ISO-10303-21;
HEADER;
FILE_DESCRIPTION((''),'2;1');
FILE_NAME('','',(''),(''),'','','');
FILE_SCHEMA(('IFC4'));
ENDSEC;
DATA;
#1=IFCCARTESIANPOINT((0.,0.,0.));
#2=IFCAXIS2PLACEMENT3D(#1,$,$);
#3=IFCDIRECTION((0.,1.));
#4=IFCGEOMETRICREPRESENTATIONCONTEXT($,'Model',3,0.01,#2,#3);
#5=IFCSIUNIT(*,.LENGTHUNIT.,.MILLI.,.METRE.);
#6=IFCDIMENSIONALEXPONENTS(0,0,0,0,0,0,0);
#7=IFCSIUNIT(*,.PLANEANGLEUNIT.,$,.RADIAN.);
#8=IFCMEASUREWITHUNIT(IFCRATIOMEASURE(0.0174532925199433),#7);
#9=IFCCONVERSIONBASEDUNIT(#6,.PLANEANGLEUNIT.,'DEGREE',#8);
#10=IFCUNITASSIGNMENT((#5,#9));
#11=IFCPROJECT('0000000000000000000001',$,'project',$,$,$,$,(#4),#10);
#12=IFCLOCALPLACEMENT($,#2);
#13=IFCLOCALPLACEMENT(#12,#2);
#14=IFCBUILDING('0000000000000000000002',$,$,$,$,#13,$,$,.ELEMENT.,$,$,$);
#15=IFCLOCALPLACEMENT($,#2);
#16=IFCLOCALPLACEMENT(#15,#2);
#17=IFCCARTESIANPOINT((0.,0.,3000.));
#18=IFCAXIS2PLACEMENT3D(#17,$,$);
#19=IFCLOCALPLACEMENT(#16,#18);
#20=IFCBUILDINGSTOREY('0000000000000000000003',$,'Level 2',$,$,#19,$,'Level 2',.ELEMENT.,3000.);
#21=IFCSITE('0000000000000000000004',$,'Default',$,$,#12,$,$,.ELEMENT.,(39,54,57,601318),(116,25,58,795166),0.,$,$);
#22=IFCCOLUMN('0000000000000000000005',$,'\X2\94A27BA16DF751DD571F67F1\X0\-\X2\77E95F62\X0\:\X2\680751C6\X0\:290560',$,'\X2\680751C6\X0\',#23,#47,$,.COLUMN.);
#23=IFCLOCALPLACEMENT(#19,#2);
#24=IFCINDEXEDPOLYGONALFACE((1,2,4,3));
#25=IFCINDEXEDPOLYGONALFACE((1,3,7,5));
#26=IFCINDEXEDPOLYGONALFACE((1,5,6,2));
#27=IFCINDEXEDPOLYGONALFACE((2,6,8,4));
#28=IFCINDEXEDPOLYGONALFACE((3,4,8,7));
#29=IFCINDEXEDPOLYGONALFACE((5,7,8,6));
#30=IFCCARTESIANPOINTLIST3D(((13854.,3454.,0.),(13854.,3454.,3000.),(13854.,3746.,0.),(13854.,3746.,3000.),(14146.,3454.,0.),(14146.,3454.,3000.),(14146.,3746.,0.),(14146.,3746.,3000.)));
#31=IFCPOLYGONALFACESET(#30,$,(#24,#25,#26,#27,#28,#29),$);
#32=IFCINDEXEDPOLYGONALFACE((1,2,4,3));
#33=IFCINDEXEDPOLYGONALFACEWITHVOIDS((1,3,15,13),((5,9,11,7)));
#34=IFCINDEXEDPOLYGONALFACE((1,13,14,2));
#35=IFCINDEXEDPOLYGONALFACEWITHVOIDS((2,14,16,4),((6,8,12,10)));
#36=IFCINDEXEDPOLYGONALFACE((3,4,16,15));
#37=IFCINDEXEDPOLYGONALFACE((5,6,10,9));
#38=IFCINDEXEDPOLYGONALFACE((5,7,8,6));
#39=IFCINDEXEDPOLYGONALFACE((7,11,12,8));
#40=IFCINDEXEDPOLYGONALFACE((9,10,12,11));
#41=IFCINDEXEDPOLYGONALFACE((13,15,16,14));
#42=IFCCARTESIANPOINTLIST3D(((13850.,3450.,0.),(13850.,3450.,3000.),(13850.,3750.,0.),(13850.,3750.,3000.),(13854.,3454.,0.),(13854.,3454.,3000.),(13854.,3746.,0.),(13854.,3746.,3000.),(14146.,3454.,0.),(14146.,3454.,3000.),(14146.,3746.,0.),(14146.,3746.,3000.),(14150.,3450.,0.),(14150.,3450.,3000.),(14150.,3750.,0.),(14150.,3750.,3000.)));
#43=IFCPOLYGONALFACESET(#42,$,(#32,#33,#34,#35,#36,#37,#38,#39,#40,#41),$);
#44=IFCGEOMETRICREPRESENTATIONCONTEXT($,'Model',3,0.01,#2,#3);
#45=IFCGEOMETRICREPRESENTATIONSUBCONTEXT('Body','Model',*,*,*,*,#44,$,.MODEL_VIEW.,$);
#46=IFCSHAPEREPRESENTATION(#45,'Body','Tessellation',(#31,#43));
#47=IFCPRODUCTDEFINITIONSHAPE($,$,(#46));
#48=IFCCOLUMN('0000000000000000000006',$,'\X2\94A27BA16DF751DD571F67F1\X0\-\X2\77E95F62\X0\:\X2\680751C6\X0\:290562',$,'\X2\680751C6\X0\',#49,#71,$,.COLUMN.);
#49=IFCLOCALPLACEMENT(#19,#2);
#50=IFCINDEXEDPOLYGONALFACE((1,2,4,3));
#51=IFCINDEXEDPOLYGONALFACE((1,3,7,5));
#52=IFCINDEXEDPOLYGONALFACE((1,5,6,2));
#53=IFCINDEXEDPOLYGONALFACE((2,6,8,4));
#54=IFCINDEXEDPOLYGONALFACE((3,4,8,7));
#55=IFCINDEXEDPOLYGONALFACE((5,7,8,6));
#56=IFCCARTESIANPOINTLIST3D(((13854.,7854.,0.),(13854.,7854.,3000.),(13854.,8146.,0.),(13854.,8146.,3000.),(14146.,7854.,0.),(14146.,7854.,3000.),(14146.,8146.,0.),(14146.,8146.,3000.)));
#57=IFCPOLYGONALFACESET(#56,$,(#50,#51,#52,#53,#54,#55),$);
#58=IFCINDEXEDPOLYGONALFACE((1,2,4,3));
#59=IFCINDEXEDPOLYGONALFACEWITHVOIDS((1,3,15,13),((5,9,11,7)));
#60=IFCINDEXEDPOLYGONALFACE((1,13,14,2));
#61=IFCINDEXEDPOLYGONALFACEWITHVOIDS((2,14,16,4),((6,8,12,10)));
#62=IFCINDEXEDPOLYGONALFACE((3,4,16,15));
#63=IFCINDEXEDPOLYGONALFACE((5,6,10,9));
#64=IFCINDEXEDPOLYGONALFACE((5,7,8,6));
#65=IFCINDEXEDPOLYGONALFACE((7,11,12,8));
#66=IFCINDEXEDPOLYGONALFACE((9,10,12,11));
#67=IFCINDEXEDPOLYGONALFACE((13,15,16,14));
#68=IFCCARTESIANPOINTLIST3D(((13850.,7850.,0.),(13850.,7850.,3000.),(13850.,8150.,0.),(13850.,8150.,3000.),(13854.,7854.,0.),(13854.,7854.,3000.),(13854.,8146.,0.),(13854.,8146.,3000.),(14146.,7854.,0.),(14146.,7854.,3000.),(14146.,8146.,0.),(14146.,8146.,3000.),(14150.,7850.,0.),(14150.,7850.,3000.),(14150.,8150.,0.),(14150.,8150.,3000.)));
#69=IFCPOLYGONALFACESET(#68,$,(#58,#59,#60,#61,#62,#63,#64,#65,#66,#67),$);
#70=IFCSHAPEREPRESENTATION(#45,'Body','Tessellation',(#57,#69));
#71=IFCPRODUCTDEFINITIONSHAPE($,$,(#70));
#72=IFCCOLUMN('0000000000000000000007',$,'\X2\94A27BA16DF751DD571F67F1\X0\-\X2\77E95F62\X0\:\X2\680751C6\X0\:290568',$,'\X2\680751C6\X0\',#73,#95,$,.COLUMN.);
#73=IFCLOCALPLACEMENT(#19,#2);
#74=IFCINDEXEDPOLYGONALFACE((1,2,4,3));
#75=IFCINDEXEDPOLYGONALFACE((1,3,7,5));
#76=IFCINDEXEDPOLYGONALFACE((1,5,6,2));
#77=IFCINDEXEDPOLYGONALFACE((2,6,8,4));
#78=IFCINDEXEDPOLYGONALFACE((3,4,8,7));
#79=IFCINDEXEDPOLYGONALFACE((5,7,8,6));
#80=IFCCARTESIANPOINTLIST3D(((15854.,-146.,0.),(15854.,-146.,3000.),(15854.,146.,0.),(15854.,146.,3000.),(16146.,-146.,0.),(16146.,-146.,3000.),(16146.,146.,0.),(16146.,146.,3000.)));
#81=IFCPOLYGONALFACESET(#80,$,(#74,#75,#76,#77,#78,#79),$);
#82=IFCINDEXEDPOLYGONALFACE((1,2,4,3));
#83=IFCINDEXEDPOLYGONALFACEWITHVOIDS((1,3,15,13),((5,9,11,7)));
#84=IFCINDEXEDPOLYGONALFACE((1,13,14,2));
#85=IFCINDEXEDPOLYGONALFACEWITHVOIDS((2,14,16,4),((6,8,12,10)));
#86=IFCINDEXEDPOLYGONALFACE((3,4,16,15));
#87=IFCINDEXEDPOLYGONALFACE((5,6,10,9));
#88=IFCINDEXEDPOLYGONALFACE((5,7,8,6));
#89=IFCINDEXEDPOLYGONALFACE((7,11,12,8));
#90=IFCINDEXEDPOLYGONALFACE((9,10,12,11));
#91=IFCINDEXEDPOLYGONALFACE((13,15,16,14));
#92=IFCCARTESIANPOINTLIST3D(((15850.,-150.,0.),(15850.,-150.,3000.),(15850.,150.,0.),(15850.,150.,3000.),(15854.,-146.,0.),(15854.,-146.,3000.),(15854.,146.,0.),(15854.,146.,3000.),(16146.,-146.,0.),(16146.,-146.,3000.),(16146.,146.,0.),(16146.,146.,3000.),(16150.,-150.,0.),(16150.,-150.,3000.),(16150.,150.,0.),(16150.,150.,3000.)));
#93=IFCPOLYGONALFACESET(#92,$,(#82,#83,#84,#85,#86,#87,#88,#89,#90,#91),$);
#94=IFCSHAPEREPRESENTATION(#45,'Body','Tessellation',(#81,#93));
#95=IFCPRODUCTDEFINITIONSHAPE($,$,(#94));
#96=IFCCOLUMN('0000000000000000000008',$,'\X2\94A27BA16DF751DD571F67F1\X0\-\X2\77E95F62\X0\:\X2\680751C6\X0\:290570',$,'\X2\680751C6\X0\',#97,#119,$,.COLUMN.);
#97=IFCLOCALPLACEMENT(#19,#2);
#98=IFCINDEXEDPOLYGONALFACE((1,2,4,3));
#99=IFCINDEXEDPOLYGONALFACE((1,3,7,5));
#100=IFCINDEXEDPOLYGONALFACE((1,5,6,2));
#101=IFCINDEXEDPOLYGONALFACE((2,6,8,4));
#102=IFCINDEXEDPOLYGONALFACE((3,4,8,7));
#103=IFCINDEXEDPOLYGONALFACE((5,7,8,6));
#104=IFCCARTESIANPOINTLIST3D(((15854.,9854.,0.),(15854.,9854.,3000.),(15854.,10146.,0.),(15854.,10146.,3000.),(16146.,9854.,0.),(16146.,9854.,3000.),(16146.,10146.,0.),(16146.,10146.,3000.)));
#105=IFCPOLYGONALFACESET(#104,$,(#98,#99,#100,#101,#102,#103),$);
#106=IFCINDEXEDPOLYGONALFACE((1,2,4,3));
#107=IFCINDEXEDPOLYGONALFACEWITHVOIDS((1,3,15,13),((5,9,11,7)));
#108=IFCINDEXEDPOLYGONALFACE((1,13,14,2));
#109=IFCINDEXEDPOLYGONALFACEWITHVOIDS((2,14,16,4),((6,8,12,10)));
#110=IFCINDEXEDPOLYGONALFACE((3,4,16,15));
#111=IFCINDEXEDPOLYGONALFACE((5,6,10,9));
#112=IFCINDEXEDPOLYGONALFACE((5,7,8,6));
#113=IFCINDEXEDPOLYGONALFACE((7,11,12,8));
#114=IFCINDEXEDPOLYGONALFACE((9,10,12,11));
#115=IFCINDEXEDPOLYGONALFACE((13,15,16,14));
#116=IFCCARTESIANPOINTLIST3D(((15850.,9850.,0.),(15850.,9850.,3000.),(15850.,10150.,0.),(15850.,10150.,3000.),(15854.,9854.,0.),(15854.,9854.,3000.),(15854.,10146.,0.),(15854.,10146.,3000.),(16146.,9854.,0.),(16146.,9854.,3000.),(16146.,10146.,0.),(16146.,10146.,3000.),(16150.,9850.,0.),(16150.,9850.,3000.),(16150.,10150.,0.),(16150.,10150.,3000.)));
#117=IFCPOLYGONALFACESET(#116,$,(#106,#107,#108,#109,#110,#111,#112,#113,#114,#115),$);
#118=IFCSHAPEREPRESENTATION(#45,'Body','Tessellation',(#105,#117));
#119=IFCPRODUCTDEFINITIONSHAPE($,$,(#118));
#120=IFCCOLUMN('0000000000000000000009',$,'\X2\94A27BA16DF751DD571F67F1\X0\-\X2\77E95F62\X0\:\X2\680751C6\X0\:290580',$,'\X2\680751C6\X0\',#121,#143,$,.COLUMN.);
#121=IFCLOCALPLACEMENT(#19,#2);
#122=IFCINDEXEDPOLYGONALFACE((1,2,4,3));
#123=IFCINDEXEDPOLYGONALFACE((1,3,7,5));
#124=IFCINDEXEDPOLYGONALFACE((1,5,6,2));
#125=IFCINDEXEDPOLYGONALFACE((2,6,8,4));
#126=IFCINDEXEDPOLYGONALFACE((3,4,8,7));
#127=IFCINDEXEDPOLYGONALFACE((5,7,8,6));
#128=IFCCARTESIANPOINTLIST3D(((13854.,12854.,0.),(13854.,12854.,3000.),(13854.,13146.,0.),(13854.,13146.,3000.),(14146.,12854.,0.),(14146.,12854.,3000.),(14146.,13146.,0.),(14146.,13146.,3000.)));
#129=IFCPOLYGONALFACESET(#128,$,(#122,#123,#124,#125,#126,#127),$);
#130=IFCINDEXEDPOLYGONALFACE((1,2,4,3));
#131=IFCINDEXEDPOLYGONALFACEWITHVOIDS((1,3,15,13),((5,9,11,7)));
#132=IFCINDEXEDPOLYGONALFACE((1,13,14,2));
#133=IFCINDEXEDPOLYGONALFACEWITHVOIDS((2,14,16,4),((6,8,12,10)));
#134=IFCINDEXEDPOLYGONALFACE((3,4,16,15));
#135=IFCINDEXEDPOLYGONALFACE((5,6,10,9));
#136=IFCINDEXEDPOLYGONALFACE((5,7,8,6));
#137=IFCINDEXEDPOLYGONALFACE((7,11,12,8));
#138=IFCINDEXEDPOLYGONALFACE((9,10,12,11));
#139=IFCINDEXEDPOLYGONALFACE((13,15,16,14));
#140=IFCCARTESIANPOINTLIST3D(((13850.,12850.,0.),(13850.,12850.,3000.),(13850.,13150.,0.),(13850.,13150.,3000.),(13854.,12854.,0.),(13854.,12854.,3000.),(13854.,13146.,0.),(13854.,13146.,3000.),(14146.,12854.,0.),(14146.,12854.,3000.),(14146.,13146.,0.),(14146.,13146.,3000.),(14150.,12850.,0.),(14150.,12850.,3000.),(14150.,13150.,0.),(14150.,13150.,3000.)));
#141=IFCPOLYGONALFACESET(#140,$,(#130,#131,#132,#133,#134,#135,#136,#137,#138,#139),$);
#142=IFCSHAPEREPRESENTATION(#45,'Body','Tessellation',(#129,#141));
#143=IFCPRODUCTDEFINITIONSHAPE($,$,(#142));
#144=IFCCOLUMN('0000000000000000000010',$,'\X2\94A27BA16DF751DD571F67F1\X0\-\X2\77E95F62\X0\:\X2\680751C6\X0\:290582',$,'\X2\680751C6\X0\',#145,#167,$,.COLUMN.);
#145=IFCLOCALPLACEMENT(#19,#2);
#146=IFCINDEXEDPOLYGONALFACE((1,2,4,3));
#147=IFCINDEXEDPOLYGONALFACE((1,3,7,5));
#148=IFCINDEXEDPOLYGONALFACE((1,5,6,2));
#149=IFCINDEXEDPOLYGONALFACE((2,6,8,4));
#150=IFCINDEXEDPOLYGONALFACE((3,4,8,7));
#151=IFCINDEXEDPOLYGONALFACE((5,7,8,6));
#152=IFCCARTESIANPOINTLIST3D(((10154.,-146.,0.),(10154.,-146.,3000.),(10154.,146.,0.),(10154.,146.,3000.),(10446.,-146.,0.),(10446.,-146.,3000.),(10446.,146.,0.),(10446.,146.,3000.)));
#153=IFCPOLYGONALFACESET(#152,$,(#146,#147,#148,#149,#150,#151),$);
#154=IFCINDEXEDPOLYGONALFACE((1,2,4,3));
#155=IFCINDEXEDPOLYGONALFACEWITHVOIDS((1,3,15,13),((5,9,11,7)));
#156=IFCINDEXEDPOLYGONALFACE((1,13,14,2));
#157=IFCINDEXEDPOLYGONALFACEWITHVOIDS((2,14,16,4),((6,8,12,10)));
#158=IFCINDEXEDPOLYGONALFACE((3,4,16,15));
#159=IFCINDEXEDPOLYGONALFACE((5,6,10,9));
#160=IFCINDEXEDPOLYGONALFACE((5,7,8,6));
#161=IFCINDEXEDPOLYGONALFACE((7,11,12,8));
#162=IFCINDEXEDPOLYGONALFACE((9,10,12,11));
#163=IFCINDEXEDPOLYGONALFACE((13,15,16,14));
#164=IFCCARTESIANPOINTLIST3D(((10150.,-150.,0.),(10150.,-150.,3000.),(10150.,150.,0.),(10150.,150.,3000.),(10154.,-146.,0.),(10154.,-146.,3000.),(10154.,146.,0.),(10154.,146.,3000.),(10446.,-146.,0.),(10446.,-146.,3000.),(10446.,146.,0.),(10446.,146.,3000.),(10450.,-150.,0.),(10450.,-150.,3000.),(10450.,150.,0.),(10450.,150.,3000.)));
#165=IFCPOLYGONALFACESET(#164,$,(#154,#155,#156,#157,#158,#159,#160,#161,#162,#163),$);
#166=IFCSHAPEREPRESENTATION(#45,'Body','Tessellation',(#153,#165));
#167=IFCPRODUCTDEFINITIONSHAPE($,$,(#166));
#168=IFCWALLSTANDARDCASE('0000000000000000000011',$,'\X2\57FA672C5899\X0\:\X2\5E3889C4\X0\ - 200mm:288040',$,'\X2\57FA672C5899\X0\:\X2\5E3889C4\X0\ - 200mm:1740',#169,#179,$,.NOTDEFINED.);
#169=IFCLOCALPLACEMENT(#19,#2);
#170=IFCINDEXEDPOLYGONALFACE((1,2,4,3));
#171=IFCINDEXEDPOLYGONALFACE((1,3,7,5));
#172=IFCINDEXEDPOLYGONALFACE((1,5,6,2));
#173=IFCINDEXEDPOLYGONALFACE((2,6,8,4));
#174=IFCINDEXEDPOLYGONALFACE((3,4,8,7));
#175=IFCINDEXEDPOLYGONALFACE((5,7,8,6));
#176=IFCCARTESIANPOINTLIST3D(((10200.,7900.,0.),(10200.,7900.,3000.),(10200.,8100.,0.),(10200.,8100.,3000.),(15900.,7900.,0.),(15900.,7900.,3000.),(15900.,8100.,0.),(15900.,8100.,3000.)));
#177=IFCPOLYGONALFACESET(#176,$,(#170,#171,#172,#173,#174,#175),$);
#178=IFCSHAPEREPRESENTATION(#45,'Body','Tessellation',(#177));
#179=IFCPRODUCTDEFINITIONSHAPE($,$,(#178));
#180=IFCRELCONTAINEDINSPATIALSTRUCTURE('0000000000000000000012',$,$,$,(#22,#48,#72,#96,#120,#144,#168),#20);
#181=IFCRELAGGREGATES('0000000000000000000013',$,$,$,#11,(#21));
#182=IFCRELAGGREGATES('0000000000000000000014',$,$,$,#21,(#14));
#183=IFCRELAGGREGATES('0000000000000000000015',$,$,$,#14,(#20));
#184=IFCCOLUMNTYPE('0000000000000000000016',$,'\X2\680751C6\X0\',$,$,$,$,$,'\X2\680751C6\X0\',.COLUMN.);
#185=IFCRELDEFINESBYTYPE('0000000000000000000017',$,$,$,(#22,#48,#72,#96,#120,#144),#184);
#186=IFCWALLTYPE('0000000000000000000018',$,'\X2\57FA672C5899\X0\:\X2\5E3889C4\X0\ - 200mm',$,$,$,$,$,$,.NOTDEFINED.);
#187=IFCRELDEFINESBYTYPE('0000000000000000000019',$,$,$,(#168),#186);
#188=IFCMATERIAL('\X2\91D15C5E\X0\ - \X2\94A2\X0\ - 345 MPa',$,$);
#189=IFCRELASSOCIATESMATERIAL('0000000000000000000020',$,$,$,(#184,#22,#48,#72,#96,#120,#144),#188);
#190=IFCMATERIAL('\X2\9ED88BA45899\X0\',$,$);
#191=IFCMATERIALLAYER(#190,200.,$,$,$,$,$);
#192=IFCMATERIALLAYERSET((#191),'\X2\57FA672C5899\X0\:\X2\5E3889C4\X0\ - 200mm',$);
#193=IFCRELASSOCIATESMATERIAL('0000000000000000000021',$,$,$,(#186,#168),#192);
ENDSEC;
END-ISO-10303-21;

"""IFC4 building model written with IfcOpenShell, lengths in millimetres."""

from ifc_helpers import new_model, entity, si_unit, converted_unit, direction, frame, frame_2d, origin, origin_2d_with_axis, place, context, subcontext, project, spatial, polyline, rectangle, outline, extrude, source, transform, mapped, material, layer, layer_set, layer_usage, type_object, type_shapes, element, save


model = new_model("IFC4")

# Units and contexts
model_context_1 = context("Model", 3, precision=0.01, world=origin(), true_north=direction((0.0, 1.0)))
model_context_2 = context("Model", 3, precision=0.01, world=origin(), true_north=direction((0.0, 1.0)))
body_context = subcontext(model_context_2, "Body", "Model", "MODEL_VIEW")
ifc_project = project(units=[si_unit("LENGTHUNIT", "METRE", prefix="MILLI"), converted_unit("PLANEANGLEUNIT", "DEGREE", entity("IfcRatioMeasure", 0.0174532925199433), si_unit("PLANEANGLEUNIT", "RADIAN"), dimensions=[0, 0, 0, 0, 0, 0, 0])], contexts=[model_context_1])

# Site, building, storey
site_placement = place(None, origin())
site = spatial("IfcSite", under=ifc_project, at=site_placement, Name="Default", CompositionType="ELEMENT", RefLatitude=(39, 54, 57, 601318), RefLongitude=(116, 25, 58, 795166), RefElevation=0.0)
building_placement = place(site_placement, origin())
building = spatial("IfcBuilding", under=site, at=building_placement, CompositionType="ELEMENT")
placement_1 = place(None, origin())
placement_2 = place(placement_1, origin())
storey_placement = place(placement_2, frame((0.0, 0.0, 3000.0)))
storey = spatial("IfcBuildingStorey", under=building, at=storey_placement, Name="Level 2", LongName="Level 2", CompositionType="ELEMENT", Elevation=3000.0)

# Columns
ifc_material_1 = material(Name="金属 - 钢 - 345 MPa")
column_type = type_object("IfcColumnType", Name="标准", ElementType="标准", PredefinedType="COLUMN", material=ifc_material_1)
shared_shape_1 = source(origin(), body_context, "Body", "SweptSolid", [
    extrude(rectangle(XDim=292.0, YDim=292.0, at=origin_2d_with_axis()), frame((150.0, 150.0, 0.0), z_axis=(0.0, 0.0, 1.0), x_axis=(-1.0, 0.0, 0.0)), (0.0, 0.0, 1.0), 3000.0),
    extrude(outline(polyline([(-150.0, -150.0), (150.0, -150.0), (150.0, 150.0), (-150.0, 150.0), (-150.0, -150.0)]), holes=[polyline([(-146.0, -146.0), (-146.0, 146.0), (146.0, 146.0), (146.0, -146.0), (-146.0, -146.0)])]), frame((150.0, 150.0, 0.0), z_axis=(0.0, 0.0, 1.0), x_axis=(-1.0, 0.0, 0.0)), (0.0, 0.0, 1.0), 3000.0),
])
type_shapes(column_type, [shared_shape_1])
for number, where, name in (
    (1, (13850.0, 3450.0, 0.0), "钢管混凝土柱-矩形:标准:290560"),
    (2, (13850.0, 7850.0, 0.0), "钢管混凝土柱-矩形:标准:290562"),
    (3, (15850.0, -150.0, 0.0), "钢管混凝土柱-矩形:标准:290568"),
    (4, (15850.0, 9850.0, 0.0), "钢管混凝土柱-矩形:标准:290570"),
    (5, (13850.0, 12850.0, 0.0), "钢管混凝土柱-矩形:标准:290580"),
    (6, (10150.0, -150.0, 0.0), "钢管混凝土柱-矩形:标准:290582"),
):
    element("IfcColumn", number, at=place(storey_placement, frame(where)), inside=storey, type_object=column_type, material=ifc_material_1, Name=name, ObjectType="标准", PredefinedType="COLUMN", context=body_context, shape_type="MappedRepresentation", body=[
        mapped(shared_shape_1, transform((0.0, 0.0, 0.0), scale=1.0)),
    ])

# Wall
ifc_material_2 = material(Name="默认墙")
ifc_layer = layer(ifc_material_2, 200.0)
ifc_layer_set = layer_set([ifc_layer], Name="基本墙:常规 - 200mm")
ifc_layer_usage_1 = layer_usage(ifc_layer_set, "AXIS2", "NEGATIVE", 100.0)
wall_type = type_object("IfcWallType", Name="基本墙:常规 - 200mm", PredefinedType="NOTDEFINED", material=ifc_layer_set)
wall_1_placement = place(storey_placement, frame((10200.0, 8000.0, 0.0)))
element("IfcWallStandardCase", 7, at=wall_1_placement, inside=storey, type_object=wall_type, material=ifc_layer_usage_1, Name="基本墙:常规 - 200mm:288040", ObjectType="基本墙:常规 - 200mm:1740", PredefinedType="NOTDEFINED", context=body_context, shape_type="SweptSolid", body=[
    extrude(rectangle(XDim=5700.0, YDim=200.0, at=frame_2d((2850.0, 0.0), x_axis=(-1.0, 0.0))), origin(), (0.0, 0.0, 1.0), 3000.0),
])

save(model, "model.ifc")
